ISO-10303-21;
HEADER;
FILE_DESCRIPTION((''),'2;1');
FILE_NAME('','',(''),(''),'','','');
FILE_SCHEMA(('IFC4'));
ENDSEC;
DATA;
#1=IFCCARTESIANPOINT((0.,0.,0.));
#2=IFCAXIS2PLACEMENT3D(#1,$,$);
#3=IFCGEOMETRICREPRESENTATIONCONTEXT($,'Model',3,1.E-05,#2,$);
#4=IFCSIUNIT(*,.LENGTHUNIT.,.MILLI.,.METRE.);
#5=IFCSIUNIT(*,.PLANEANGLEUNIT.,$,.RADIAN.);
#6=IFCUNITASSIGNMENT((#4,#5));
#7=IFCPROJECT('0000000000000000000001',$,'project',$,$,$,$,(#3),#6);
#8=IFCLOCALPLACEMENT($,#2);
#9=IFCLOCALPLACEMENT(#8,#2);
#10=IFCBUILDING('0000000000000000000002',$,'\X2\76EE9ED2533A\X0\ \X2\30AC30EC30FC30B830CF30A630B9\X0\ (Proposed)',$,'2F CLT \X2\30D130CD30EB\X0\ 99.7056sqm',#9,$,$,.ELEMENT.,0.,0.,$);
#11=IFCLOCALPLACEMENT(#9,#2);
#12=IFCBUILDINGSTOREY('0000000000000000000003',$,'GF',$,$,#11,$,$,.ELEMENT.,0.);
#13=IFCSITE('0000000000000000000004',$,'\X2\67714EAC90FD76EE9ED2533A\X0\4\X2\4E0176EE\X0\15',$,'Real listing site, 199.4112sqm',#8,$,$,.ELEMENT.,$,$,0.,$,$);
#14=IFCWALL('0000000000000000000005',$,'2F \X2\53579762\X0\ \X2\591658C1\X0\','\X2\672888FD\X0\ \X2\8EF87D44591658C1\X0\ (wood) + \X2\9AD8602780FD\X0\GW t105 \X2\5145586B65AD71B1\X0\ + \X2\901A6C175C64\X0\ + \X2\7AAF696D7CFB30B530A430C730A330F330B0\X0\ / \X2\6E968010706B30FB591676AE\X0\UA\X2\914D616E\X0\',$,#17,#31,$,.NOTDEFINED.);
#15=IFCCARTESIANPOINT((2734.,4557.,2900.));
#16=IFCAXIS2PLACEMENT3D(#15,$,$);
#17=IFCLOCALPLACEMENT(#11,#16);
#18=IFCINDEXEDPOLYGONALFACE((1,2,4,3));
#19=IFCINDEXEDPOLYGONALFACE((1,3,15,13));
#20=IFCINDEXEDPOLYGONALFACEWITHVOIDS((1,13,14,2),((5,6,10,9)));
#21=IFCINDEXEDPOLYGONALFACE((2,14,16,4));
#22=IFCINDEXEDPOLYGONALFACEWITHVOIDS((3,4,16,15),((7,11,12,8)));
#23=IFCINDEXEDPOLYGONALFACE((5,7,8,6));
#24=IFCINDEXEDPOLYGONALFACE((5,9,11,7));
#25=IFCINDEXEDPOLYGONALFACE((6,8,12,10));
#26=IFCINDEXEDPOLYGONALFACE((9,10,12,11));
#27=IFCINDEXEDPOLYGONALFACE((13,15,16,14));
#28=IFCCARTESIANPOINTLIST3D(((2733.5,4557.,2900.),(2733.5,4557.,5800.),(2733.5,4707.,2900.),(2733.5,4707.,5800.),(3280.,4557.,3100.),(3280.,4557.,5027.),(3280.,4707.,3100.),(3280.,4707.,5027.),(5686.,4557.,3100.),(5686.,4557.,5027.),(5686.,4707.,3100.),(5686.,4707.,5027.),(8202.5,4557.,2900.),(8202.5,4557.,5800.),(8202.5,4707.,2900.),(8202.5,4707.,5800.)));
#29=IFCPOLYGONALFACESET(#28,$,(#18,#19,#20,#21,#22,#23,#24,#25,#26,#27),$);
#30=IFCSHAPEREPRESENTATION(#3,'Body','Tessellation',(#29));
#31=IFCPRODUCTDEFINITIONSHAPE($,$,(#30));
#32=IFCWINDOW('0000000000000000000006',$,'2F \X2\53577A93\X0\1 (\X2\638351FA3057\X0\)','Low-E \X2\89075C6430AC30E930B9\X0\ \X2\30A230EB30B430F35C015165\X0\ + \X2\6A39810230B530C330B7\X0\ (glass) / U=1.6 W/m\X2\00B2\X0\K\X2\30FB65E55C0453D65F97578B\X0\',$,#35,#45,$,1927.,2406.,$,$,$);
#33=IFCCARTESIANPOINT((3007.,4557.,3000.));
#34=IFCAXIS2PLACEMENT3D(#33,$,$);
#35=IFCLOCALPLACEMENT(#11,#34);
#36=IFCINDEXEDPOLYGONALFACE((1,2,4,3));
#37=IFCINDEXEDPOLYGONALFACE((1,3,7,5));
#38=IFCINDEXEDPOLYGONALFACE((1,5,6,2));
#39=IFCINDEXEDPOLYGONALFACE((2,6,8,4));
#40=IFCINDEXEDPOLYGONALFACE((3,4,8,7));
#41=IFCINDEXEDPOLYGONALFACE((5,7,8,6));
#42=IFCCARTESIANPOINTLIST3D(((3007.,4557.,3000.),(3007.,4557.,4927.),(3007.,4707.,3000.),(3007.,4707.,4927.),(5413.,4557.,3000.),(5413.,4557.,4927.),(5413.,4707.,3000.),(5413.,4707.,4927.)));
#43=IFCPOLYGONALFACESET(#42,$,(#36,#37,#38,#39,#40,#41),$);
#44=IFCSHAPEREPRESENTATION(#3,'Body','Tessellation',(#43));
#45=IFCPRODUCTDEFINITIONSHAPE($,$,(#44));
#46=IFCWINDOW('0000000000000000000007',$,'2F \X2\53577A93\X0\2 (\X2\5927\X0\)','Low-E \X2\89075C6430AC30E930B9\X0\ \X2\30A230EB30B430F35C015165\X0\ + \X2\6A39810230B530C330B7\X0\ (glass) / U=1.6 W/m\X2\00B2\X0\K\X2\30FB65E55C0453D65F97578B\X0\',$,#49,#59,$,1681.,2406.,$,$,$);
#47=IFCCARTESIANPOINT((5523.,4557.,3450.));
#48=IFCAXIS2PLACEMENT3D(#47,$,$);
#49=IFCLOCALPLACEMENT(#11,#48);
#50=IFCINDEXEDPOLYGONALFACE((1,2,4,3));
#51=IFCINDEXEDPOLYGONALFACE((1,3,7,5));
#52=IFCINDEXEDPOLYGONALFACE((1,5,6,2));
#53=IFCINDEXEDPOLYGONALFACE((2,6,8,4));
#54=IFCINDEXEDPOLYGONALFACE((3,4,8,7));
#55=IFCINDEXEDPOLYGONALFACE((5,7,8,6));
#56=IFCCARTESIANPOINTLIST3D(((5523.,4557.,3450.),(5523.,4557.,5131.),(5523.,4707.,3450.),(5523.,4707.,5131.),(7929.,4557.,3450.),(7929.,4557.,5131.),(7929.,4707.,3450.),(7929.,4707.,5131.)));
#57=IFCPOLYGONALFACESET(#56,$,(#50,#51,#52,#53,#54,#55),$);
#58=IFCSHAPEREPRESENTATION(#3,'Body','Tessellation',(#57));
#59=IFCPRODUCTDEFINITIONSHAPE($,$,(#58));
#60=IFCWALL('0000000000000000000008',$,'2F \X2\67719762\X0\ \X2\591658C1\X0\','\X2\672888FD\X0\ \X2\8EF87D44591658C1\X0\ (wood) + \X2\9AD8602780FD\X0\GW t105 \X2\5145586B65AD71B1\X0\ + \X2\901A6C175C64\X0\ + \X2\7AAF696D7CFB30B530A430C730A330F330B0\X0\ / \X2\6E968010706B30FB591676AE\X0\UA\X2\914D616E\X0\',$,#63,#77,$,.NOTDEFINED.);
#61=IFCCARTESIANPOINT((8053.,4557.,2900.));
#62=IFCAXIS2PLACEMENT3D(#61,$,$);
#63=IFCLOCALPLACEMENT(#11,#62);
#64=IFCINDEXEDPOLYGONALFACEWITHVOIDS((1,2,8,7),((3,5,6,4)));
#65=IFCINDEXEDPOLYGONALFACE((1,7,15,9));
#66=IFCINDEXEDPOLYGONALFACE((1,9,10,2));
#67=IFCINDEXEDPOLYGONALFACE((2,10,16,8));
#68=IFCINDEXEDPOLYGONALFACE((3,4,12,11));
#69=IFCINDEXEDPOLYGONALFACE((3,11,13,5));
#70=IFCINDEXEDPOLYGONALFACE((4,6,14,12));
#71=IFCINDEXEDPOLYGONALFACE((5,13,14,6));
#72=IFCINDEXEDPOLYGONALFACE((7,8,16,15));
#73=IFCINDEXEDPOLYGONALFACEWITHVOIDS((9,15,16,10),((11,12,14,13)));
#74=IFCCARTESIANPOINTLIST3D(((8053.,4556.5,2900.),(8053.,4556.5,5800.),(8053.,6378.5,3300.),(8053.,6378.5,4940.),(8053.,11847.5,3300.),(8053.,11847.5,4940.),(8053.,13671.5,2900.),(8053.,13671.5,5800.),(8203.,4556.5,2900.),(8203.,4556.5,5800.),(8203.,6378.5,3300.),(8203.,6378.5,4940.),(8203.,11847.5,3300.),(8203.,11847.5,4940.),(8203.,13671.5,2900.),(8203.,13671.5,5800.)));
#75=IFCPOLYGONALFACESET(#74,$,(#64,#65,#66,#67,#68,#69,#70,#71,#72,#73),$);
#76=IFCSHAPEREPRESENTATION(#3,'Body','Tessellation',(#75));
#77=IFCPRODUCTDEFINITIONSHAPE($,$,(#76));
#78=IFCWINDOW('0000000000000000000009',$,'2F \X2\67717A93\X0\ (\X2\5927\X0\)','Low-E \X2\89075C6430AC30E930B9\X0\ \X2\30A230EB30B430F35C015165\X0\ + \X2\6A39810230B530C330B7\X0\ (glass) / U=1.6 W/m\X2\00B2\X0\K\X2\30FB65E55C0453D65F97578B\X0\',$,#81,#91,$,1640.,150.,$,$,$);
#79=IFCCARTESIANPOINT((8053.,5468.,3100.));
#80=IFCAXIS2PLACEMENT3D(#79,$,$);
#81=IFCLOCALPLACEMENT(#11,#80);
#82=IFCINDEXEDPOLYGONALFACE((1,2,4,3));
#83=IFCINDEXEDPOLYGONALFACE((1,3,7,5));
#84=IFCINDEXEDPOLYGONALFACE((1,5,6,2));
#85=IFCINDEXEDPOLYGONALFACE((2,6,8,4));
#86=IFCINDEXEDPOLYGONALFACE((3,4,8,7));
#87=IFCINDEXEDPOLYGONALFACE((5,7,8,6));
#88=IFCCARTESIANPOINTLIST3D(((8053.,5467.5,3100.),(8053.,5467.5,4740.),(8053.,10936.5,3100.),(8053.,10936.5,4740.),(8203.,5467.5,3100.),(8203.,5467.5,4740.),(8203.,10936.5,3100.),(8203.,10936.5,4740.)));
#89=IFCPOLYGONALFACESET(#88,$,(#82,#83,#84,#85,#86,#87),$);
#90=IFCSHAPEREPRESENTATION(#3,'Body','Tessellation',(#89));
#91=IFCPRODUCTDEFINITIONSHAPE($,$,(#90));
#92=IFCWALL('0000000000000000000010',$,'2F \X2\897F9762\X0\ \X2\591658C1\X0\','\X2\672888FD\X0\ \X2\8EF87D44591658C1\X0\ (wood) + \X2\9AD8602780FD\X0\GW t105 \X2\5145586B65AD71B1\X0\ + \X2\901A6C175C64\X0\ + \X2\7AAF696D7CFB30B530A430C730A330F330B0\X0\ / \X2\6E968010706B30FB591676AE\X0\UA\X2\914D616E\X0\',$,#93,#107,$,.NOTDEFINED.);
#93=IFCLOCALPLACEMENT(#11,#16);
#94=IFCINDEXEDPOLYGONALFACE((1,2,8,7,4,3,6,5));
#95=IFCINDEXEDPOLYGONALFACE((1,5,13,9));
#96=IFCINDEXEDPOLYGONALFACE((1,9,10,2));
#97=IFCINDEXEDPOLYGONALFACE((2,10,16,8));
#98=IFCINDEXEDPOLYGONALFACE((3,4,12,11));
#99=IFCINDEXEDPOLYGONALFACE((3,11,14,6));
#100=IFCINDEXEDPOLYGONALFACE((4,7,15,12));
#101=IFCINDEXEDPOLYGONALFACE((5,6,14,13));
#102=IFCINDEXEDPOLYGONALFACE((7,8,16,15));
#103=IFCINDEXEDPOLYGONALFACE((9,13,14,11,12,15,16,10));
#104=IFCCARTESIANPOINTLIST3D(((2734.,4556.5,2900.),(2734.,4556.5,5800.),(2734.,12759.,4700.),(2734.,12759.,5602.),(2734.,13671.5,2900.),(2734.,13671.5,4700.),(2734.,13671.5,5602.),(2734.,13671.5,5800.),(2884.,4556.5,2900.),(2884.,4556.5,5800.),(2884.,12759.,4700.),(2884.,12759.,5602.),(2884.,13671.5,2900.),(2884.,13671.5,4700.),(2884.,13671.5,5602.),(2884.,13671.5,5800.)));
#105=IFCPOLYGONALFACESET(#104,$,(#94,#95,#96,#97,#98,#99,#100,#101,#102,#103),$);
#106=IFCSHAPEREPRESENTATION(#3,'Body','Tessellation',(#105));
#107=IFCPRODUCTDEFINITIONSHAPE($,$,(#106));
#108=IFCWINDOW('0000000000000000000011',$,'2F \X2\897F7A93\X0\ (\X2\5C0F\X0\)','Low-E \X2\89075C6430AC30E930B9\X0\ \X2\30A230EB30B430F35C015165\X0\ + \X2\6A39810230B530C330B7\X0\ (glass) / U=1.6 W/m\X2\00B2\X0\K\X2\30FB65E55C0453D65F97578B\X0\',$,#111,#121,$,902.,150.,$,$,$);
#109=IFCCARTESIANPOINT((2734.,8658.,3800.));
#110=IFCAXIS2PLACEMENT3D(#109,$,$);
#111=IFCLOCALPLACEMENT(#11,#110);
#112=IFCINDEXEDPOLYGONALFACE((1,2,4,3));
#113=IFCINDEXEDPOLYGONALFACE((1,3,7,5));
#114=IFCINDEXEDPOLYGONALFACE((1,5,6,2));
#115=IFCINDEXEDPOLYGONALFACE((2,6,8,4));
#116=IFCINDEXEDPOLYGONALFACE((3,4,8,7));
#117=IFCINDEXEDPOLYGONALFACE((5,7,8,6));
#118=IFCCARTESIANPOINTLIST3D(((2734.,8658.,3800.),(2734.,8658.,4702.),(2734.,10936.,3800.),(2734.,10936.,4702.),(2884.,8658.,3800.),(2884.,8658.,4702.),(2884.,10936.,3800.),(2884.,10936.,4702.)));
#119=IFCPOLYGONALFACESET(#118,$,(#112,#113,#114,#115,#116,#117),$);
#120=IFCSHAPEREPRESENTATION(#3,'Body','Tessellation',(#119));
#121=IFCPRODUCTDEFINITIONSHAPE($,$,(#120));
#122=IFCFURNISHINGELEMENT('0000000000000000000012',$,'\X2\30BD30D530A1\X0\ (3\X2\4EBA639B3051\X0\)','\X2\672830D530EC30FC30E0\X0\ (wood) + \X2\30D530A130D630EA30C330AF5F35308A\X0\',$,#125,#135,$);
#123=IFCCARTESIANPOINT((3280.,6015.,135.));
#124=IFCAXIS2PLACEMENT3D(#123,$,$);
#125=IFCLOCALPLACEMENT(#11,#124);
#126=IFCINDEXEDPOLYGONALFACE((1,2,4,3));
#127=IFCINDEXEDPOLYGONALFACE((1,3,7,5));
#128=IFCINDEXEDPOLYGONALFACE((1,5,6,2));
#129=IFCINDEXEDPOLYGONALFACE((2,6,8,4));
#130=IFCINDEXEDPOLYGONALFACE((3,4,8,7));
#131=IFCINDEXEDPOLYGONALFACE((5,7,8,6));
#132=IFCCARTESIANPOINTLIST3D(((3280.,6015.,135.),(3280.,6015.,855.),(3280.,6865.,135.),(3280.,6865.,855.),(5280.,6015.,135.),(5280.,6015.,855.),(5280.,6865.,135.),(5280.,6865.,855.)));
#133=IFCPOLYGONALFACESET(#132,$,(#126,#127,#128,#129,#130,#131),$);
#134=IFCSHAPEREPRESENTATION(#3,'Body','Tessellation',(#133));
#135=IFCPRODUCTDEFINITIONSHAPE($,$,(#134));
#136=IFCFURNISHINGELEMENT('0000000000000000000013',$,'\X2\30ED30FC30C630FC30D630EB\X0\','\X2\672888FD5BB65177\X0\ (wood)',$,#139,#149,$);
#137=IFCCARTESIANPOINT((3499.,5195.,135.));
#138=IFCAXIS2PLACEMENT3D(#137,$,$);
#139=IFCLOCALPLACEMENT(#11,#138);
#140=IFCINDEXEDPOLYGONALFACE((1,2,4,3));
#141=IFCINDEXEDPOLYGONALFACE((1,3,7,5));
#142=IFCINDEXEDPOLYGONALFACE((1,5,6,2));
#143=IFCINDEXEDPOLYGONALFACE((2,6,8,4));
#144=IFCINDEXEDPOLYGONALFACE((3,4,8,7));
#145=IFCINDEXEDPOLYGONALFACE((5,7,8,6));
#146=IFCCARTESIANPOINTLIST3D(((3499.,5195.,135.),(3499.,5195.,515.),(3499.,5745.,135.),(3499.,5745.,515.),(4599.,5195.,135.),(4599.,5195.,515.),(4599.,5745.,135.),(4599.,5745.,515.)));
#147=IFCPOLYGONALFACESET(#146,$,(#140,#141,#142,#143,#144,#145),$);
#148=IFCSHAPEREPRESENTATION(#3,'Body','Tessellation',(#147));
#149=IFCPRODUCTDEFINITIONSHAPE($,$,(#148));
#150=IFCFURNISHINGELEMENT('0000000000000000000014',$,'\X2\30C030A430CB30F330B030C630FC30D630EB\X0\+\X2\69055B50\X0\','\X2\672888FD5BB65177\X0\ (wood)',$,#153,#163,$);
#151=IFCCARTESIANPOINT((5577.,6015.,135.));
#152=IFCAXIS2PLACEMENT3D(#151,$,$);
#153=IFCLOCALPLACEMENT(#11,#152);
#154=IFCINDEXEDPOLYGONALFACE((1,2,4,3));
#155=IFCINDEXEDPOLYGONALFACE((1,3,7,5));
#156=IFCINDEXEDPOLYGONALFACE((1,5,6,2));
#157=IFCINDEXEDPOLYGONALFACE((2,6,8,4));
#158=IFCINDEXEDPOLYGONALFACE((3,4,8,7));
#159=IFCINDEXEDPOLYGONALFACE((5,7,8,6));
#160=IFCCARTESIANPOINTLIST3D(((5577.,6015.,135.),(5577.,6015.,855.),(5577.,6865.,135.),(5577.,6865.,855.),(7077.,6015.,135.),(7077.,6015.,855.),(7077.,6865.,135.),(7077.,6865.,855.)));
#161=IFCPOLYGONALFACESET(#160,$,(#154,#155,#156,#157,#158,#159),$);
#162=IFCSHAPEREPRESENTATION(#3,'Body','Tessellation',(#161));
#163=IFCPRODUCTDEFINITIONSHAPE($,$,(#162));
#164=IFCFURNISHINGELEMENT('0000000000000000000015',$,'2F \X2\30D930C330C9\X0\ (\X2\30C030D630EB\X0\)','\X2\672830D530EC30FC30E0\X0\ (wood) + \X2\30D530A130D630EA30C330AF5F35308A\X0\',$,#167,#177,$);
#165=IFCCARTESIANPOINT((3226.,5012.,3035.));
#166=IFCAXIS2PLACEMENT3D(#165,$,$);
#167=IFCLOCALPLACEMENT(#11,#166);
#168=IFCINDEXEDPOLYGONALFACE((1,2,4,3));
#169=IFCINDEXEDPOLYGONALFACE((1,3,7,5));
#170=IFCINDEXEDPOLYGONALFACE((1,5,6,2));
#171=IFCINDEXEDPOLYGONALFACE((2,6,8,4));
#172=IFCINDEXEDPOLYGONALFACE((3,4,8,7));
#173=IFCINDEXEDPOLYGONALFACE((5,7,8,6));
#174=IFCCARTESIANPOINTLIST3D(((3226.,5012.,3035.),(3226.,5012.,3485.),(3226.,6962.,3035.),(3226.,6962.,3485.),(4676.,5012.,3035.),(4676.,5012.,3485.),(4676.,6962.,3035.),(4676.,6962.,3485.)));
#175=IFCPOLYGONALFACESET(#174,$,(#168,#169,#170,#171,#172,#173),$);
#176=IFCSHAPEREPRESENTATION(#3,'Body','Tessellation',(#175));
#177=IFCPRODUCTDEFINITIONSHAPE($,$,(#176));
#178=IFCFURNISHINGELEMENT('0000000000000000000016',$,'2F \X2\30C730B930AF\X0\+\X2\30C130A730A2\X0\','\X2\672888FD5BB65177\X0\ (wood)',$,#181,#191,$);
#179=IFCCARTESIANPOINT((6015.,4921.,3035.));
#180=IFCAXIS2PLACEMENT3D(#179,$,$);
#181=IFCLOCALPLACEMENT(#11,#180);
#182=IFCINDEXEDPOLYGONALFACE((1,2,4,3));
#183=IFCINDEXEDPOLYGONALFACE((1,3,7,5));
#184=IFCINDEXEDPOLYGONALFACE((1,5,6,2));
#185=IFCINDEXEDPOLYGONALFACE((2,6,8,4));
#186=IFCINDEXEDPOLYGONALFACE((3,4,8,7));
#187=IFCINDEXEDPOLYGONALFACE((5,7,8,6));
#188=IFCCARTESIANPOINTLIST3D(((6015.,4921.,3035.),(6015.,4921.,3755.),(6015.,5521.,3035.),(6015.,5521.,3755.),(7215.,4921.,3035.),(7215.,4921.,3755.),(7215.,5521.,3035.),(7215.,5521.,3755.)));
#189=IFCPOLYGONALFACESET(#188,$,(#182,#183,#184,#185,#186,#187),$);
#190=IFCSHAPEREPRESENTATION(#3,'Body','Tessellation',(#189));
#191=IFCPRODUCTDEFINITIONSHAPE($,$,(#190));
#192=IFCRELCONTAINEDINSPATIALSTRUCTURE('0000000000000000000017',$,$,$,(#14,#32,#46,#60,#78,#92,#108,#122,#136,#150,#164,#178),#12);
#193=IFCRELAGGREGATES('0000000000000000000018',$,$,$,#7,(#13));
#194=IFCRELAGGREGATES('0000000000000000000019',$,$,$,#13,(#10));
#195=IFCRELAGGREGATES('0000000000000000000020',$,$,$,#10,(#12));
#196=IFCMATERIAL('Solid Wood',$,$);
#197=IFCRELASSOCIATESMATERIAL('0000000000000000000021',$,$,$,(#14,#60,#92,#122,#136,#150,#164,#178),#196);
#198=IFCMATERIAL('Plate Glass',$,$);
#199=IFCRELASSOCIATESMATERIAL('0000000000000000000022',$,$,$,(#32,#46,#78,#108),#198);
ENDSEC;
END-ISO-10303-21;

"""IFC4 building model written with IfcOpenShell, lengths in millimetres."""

from ifc_helpers import new_model, si_unit, frame, frame_2d, origin, place, context, project, spatial, rectangle, extrude, material, element, fill, save


model = new_model("IFC4")

# Units and contexts
model_context = context("Model", 3, precision=1e-05, world=origin())
ifc_project = project(units=[si_unit("LENGTHUNIT", "METRE", prefix="MILLI"), si_unit("PLANEANGLEUNIT", "RADIAN")], contexts=[model_context])

# Site, building, storey
site_placement = place(None, origin())
site = spatial("IfcSite", under=ifc_project, at=site_placement, Name="東京都目黒区4丁目15", ObjectType="Real listing site, 199.4112sqm", CompositionType="ELEMENT", RefElevation=0.0)
building_placement = place(site_placement, origin())
building = spatial("IfcBuilding", under=site, at=building_placement, Name="目黒区 ガレージハウス (Proposed)", ObjectType="2F CLT パネル 99.7056sqm", CompositionType="ELEMENT", ElevationOfRefHeight=0.0, ElevationOfTerrain=0.0)
storey_placement = place(building_placement, origin())
storey = spatial("IfcBuildingStorey", under=building, at=storey_placement, Name="GF", CompositionType="ELEMENT", Elevation=0.0)

# Shared definitions
ifc_material_1 = material(Name="Solid Wood")

# Wall, openings, windows
wall_1_placement = place(storey_placement, frame((2734.0, 4557.0, 2900.0)))
wall_1 = element("IfcWall", 1, at=wall_1_placement, inside=storey, material=ifc_material_1, Name="2F 南面 外壁", Description="木製 軸組外壁 (wood) + 高性能GW t105 充填断熱 + 通気層 + 窯業系サイディング / 準耐火・外皮UA配慮", PredefinedType="NOTDEFINED", context=model_context, shape_type="SweptSolid", body=[
    extrude(rectangle(XDim=5469.0, YDim=150.0, at=frame_2d((2734.0, 75.0))), frame((2734.0, 4557.0, 2900.0)), (0.0, 0.0, 1.0), 2900.0),
])
opening_1_placement = place(storey_placement, frame((3007.0, 4557.0, 3000.0)))
opening_1 = element("IfcOpeningElement", 2, at=opening_1_placement, cuts=wall_1, PredefinedType="NOTDEFINED", context=model_context, shape_type="SweptSolid", body=[
    extrude(rectangle(XDim=2406.0, YDim=150.0, at=frame_2d((1203.0, 75.0))), frame((3007.0, 4557.0, 3000.0)), (0.0, 0.0, 1.0), 1927.0),
])
opening_2_placement = place(storey_placement, frame((5523.0, 4557.0, 3450.0)))
opening_2 = element("IfcOpeningElement", 3, at=opening_2_placement, cuts=wall_1, PredefinedType="NOTDEFINED", context=model_context, shape_type="SweptSolid", body=[
    extrude(rectangle(XDim=2406.0, YDim=150.0, at=frame_2d((1203.0, 75.0))), frame((5523.0, 4557.0, 3450.0)), (0.0, 0.0, 1.0), 1681.0),
])
ifc_material_2 = material(Name="Plate Glass")
window_1_placement = place(storey_placement, frame((3007.0, 4557.0, 3000.0)))
window_1 = element("IfcWindow", 4, at=window_1_placement, inside=storey, material=ifc_material_2, Name="2F 南窓1 (掃出し)", Description="Low-E 複層ガラス アルゴン封入 + 樹脂サッシ (glass) / U=1.6 W/m²K・日射取得型", OverallHeight=1927.0, OverallWidth=2406.0, context=model_context, shape_type="SweptSolid", body=[
    extrude(rectangle(XDim=2406.0, YDim=150.0, at=frame_2d((1203.0, 75.0))), frame((3007.0, 4557.0, 3000.0)), (0.0, 0.0, 1.0), 1927.0),
])
fill(opening_1, window_1)
window_2_placement = place(storey_placement, frame((5523.0, 4557.0, 3450.0)))
window_2 = element("IfcWindow", 5, at=window_2_placement, inside=storey, material=ifc_material_2, Name="2F 南窓2 (大)", Description="Low-E 複層ガラス アルゴン封入 + 樹脂サッシ (glass) / U=1.6 W/m²K・日射取得型", OverallHeight=1681.0, OverallWidth=2406.0, context=model_context, shape_type="SweptSolid", body=[
    extrude(rectangle(XDim=2406.0, YDim=150.0, at=frame_2d((1203.0, 75.0))), frame((5523.0, 4557.0, 3450.0)), (0.0, 0.0, 1.0), 1681.0),
])
fill(opening_2, window_2)

# Walls, openings, windows
wall_2_placement = place(storey_placement, frame((8053.0, 4557.0, 2900.0)))
wall_2 = element("IfcWall", 6, at=wall_2_placement, inside=storey, material=ifc_material_1, Name="2F 東面 外壁", Description="木製 軸組外壁 (wood) + 高性能GW t105 充填断熱 + 通気層 + 窯業系サイディング / 準耐火・外皮UA配慮", PredefinedType="NOTDEFINED", context=model_context, shape_type="SweptSolid", body=[
    extrude(rectangle(XDim=150.0, YDim=9115.0, at=frame_2d((75.0, 4557.0))), frame((8053.0, 4557.0, 2900.0)), (0.0, 0.0, 1.0), 2900.0),
])
opening_3_placement = place(storey_placement, frame((8053.0, 5468.0, 3100.0)))
opening_3 = element("IfcOpeningElement", 7, at=opening_3_placement, cuts=wall_2, PredefinedType="NOTDEFINED", context=model_context, shape_type="SweptSolid", body=[
    extrude(rectangle(XDim=150.0, YDim=5469.0, at=frame_2d((75.0, 2734.0))), frame((8053.0, 5468.0, 3100.0)), (0.0, 0.0, 1.0), 1640.0),
])
window_3_placement = place(storey_placement, frame((8053.0, 5468.0, 3100.0)))
window_3 = element("IfcWindow", 8, at=window_3_placement, inside=storey, material=ifc_material_2, Name="2F 東窓 (大)", Description="Low-E 複層ガラス アルゴン封入 + 樹脂サッシ (glass) / U=1.6 W/m²K・日射取得型", OverallHeight=1640.0, OverallWidth=150.0, context=model_context, shape_type="SweptSolid", body=[
    extrude(rectangle(XDim=150.0, YDim=5469.0, at=frame_2d((75.0, 2734.0))), frame((8053.0, 5468.0, 3100.0)), (0.0, 0.0, 1.0), 1640.0),
])
fill(opening_3, window_3)
wall_3_placement = place(storey_placement, frame((2734.0, 4557.0, 2900.0)))
wall_3 = element("IfcWall", 9, at=wall_3_placement, inside=storey, material=ifc_material_1, Name="2F 西面 外壁", Description="木製 軸組外壁 (wood) + 高性能GW t105 充填断熱 + 通気層 + 窯業系サイディング / 準耐火・外皮UA配慮", PredefinedType="NOTDEFINED", context=model_context, shape_type="SweptSolid", body=[
    extrude(rectangle(XDim=150.0, YDim=9115.0, at=frame_2d((75.0, 4557.0))), frame((2734.0, 4557.0, 2900.0)), (0.0, 0.0, 1.0), 2900.0),
])
opening_4_placement = place(storey_placement, frame((2734.0, 8658.0, 3800.0)))
opening_4 = element("IfcOpeningElement", 10, at=opening_4_placement, cuts=wall_3, PredefinedType="NOTDEFINED", context=model_context, shape_type="SweptSolid", body=[
    extrude(rectangle(XDim=150.0, YDim=2278.0, at=frame_2d((75.0, 1139.0))), frame((2734.0, 8658.0, 3800.0)), (0.0, 0.0, 1.0), 902.0),
])
window_4_placement = place(storey_placement, frame((2734.0, 8658.0, 3800.0)))
window_4 = element("IfcWindow", 11, at=window_4_placement, inside=storey, material=ifc_material_2, Name="2F 西窓 (小)", Description="Low-E 複層ガラス アルゴン封入 + 樹脂サッシ (glass) / U=1.6 W/m²K・日射取得型", OverallHeight=902.0, OverallWidth=150.0, context=model_context, shape_type="SweptSolid", body=[
    extrude(rectangle(XDim=150.0, YDim=2278.0, at=frame_2d((75.0, 1139.0))), frame((2734.0, 8658.0, 3800.0)), (0.0, 0.0, 1.0), 902.0),
])
fill(opening_4, window_4)

# Furnishing elements
furnishing_1_placement = place(storey_placement, frame((3280.0, 6015.0, 135.0)))
element("IfcFurnishingElement", 12, at=furnishing_1_placement, inside=storey, material=ifc_material_1, Name="ソファ (3人掛け)", Description="木フレーム (wood) + ファブリック張り", context=model_context, shape_type="SweptSolid", body=[
    extrude(rectangle(XDim=2000.0, YDim=850.0, at=frame_2d((1000.0, 425.0))), frame((3280.0, 6015.0, 135.0)), (0.0, 0.0, 1.0), 720.0),
])
furnishing_2_placement = place(storey_placement, frame((3499.0, 5195.0, 135.0)))
element("IfcFurnishingElement", 13, at=furnishing_2_placement, inside=storey, material=ifc_material_1, Name="ローテーブル", Description="木製家具 (wood)", context=model_context, shape_type="SweptSolid", body=[
    extrude(rectangle(XDim=1100.0, YDim=550.0, at=frame_2d((550.0, 275.0))), frame((3499.0, 5195.0, 135.0)), (0.0, 0.0, 1.0), 380.0),
])
furnishing_3_placement = place(storey_placement, frame((5577.0, 6015.0, 135.0)))
element("IfcFurnishingElement", 14, at=furnishing_3_placement, inside=storey, material=ifc_material_1, Name="ダイニングテーブル+椅子", Description="木製家具 (wood)", context=model_context, shape_type="SweptSolid", body=[
    extrude(rectangle(XDim=1500.0, YDim=850.0, at=frame_2d((750.0, 425.0))), frame((5577.0, 6015.0, 135.0)), (0.0, 0.0, 1.0), 720.0),
])
furnishing_4_placement = place(storey_placement, frame((3226.0, 5012.0, 3035.0)))
element("IfcFurnishingElement", 15, at=furnishing_4_placement, inside=storey, material=ifc_material_1, Name="2F ベッド (ダブル)", Description="木フレーム (wood) + ファブリック張り", context=model_context, shape_type="SweptSolid", body=[
    extrude(rectangle(XDim=1450.0, YDim=1950.0, at=frame_2d((725.0, 975.0))), frame((3226.0, 5012.0, 3035.0)), (0.0, 0.0, 1.0), 450.0),
])
furnishing_5_placement = place(storey_placement, frame((6015.0, 4921.0, 3035.0)))
element("IfcFurnishingElement", 16, at=furnishing_5_placement, inside=storey, material=ifc_material_1, Name="2F デスク+チェア", Description="木製家具 (wood)", context=model_context, shape_type="SweptSolid", body=[
    extrude(rectangle(XDim=1200.0, YDim=600.0, at=frame_2d((600.0, 300.0))), frame((6015.0, 4921.0, 3035.0)), (0.0, 0.0, 1.0), 720.0),
])

save(model, "model.ifc")
